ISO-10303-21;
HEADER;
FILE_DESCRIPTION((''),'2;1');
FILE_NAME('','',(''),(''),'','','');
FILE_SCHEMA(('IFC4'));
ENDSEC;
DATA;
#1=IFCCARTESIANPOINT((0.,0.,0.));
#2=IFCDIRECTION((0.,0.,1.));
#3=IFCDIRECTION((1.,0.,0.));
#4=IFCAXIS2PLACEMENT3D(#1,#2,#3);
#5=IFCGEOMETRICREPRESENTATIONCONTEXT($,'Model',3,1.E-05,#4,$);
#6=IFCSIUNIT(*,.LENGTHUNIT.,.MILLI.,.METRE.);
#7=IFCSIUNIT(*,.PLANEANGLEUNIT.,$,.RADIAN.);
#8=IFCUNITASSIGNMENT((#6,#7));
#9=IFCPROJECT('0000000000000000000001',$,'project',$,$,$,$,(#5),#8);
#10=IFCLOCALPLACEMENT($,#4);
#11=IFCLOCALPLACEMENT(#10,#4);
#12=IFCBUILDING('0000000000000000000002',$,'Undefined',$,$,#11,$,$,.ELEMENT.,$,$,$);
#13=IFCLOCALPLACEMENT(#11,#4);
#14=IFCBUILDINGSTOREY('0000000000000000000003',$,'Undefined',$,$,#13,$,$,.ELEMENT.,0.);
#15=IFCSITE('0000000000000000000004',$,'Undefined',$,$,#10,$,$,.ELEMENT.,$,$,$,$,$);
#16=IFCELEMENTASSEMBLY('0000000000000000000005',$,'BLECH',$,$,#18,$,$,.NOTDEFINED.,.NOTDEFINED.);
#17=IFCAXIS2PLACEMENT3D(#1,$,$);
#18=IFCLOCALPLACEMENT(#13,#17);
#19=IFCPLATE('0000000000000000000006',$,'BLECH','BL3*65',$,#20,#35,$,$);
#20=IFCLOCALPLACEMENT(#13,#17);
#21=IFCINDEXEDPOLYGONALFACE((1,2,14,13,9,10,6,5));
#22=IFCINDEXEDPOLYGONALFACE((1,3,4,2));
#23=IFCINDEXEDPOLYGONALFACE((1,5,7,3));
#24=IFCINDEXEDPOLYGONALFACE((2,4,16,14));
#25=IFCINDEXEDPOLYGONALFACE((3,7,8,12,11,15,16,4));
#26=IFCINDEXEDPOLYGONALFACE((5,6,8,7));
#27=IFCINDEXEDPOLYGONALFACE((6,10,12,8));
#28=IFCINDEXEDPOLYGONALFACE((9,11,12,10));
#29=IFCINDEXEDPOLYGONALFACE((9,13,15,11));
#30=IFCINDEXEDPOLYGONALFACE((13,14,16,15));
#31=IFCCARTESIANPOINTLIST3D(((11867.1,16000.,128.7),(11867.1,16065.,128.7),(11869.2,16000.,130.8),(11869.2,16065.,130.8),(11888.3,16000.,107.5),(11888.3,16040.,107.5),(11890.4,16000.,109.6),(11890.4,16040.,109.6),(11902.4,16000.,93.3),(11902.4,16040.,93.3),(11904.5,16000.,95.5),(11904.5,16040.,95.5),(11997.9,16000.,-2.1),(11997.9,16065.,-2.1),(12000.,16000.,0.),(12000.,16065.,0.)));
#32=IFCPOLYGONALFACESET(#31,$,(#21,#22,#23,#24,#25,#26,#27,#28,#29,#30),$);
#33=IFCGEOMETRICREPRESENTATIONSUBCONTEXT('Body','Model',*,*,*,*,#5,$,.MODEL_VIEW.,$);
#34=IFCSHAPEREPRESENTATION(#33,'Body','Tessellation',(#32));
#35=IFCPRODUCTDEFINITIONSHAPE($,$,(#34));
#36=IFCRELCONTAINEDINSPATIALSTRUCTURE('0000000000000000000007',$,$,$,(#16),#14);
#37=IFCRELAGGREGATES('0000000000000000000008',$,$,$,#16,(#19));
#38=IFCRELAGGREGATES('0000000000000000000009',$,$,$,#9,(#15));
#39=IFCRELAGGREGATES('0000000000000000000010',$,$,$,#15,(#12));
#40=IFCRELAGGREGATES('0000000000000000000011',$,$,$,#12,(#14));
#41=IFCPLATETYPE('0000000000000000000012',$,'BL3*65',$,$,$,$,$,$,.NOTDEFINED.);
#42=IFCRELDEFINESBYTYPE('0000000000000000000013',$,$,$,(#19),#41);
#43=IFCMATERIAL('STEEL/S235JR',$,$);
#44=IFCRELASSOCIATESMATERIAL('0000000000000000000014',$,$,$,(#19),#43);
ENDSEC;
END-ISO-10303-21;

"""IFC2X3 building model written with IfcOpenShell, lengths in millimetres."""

from ifc_helpers import new_model, si_unit, frame, origin_with_axes, place, context, subcontext, project, spatial, polyline, outline, extrude, material, type_object, element, aggregate, save


model = new_model("IFC2X3")

# Units and contexts
model_context = context("Model", 3, precision=1e-05, world=origin_with_axes())
body_context = subcontext(model_context, "Body", "Model", "MODEL_VIEW")
ifc_project = project(units=[si_unit("LENGTHUNIT", "METRE", prefix="MILLI"), si_unit("PLANEANGLEUNIT", "RADIAN")], contexts=[model_context])

# Site, building, storey
site_placement = place(None, origin_with_axes())
site = spatial("IfcSite", under=ifc_project, at=site_placement, Name="Undefined", CompositionType="ELEMENT")
building_placement = place(site_placement, origin_with_axes())
building = spatial("IfcBuilding", under=site, at=building_placement, Name="Undefined", CompositionType="ELEMENT")
storey_placement = place(building_placement, origin_with_axes())
storey = spatial("IfcBuildingStorey", under=building, at=storey_placement, Name="Undefined", CompositionType="ELEMENT", Elevation=0.0)

# Shared definitions
ifc_material = material(Name="STEEL/S235JR")

# Element assembly, plate
plate_type_1 = type_object("IfcPlateType", Name="BL3*65", PredefinedType="NOTDEFINED")
assembly_1_placement = place(storey_placement, origin_with_axes())
assembly_1 = element("IfcElementAssembly", 1, at=assembly_1_placement, inside=storey, Name="BLECH", AssemblyPlace="NOTDEFINED", PredefinedType="NOTDEFINED")
plate_1_placement = place(assembly_1_placement, frame((11998.9, 16065.0, -1.1), z_axis=(0.707107, 0.0, 0.707107), x_axis=(-0.707107, 0.0, 0.707107)))
plate_1 = element("IfcPlate", 2, at=plate_1_placement, type_object=plate_type_1, material=ifc_material, Name="BLECH", Description="BL3*65", context=body_context, shape_type="SweptSolid", body=[
    extrude(outline(polyline([(0.0, 0.0), (185.0, 0.0), (185.0, 65.0), (155.0, 65.0), (155.0, 25.0), (135.0, 25.0), (135.0, 65.0), (0.0, 65.0), (0.0, 0.0)])), frame((0.0, 0.0, -1.5), z_axis=(0.0, 0.0, 1.0), x_axis=(1.0, 0.0, 0.0)), (0.0, 0.0, 1.0), 3.0),
])
aggregate(assembly_1, [plate_1])

save(model, "model.ifc")
